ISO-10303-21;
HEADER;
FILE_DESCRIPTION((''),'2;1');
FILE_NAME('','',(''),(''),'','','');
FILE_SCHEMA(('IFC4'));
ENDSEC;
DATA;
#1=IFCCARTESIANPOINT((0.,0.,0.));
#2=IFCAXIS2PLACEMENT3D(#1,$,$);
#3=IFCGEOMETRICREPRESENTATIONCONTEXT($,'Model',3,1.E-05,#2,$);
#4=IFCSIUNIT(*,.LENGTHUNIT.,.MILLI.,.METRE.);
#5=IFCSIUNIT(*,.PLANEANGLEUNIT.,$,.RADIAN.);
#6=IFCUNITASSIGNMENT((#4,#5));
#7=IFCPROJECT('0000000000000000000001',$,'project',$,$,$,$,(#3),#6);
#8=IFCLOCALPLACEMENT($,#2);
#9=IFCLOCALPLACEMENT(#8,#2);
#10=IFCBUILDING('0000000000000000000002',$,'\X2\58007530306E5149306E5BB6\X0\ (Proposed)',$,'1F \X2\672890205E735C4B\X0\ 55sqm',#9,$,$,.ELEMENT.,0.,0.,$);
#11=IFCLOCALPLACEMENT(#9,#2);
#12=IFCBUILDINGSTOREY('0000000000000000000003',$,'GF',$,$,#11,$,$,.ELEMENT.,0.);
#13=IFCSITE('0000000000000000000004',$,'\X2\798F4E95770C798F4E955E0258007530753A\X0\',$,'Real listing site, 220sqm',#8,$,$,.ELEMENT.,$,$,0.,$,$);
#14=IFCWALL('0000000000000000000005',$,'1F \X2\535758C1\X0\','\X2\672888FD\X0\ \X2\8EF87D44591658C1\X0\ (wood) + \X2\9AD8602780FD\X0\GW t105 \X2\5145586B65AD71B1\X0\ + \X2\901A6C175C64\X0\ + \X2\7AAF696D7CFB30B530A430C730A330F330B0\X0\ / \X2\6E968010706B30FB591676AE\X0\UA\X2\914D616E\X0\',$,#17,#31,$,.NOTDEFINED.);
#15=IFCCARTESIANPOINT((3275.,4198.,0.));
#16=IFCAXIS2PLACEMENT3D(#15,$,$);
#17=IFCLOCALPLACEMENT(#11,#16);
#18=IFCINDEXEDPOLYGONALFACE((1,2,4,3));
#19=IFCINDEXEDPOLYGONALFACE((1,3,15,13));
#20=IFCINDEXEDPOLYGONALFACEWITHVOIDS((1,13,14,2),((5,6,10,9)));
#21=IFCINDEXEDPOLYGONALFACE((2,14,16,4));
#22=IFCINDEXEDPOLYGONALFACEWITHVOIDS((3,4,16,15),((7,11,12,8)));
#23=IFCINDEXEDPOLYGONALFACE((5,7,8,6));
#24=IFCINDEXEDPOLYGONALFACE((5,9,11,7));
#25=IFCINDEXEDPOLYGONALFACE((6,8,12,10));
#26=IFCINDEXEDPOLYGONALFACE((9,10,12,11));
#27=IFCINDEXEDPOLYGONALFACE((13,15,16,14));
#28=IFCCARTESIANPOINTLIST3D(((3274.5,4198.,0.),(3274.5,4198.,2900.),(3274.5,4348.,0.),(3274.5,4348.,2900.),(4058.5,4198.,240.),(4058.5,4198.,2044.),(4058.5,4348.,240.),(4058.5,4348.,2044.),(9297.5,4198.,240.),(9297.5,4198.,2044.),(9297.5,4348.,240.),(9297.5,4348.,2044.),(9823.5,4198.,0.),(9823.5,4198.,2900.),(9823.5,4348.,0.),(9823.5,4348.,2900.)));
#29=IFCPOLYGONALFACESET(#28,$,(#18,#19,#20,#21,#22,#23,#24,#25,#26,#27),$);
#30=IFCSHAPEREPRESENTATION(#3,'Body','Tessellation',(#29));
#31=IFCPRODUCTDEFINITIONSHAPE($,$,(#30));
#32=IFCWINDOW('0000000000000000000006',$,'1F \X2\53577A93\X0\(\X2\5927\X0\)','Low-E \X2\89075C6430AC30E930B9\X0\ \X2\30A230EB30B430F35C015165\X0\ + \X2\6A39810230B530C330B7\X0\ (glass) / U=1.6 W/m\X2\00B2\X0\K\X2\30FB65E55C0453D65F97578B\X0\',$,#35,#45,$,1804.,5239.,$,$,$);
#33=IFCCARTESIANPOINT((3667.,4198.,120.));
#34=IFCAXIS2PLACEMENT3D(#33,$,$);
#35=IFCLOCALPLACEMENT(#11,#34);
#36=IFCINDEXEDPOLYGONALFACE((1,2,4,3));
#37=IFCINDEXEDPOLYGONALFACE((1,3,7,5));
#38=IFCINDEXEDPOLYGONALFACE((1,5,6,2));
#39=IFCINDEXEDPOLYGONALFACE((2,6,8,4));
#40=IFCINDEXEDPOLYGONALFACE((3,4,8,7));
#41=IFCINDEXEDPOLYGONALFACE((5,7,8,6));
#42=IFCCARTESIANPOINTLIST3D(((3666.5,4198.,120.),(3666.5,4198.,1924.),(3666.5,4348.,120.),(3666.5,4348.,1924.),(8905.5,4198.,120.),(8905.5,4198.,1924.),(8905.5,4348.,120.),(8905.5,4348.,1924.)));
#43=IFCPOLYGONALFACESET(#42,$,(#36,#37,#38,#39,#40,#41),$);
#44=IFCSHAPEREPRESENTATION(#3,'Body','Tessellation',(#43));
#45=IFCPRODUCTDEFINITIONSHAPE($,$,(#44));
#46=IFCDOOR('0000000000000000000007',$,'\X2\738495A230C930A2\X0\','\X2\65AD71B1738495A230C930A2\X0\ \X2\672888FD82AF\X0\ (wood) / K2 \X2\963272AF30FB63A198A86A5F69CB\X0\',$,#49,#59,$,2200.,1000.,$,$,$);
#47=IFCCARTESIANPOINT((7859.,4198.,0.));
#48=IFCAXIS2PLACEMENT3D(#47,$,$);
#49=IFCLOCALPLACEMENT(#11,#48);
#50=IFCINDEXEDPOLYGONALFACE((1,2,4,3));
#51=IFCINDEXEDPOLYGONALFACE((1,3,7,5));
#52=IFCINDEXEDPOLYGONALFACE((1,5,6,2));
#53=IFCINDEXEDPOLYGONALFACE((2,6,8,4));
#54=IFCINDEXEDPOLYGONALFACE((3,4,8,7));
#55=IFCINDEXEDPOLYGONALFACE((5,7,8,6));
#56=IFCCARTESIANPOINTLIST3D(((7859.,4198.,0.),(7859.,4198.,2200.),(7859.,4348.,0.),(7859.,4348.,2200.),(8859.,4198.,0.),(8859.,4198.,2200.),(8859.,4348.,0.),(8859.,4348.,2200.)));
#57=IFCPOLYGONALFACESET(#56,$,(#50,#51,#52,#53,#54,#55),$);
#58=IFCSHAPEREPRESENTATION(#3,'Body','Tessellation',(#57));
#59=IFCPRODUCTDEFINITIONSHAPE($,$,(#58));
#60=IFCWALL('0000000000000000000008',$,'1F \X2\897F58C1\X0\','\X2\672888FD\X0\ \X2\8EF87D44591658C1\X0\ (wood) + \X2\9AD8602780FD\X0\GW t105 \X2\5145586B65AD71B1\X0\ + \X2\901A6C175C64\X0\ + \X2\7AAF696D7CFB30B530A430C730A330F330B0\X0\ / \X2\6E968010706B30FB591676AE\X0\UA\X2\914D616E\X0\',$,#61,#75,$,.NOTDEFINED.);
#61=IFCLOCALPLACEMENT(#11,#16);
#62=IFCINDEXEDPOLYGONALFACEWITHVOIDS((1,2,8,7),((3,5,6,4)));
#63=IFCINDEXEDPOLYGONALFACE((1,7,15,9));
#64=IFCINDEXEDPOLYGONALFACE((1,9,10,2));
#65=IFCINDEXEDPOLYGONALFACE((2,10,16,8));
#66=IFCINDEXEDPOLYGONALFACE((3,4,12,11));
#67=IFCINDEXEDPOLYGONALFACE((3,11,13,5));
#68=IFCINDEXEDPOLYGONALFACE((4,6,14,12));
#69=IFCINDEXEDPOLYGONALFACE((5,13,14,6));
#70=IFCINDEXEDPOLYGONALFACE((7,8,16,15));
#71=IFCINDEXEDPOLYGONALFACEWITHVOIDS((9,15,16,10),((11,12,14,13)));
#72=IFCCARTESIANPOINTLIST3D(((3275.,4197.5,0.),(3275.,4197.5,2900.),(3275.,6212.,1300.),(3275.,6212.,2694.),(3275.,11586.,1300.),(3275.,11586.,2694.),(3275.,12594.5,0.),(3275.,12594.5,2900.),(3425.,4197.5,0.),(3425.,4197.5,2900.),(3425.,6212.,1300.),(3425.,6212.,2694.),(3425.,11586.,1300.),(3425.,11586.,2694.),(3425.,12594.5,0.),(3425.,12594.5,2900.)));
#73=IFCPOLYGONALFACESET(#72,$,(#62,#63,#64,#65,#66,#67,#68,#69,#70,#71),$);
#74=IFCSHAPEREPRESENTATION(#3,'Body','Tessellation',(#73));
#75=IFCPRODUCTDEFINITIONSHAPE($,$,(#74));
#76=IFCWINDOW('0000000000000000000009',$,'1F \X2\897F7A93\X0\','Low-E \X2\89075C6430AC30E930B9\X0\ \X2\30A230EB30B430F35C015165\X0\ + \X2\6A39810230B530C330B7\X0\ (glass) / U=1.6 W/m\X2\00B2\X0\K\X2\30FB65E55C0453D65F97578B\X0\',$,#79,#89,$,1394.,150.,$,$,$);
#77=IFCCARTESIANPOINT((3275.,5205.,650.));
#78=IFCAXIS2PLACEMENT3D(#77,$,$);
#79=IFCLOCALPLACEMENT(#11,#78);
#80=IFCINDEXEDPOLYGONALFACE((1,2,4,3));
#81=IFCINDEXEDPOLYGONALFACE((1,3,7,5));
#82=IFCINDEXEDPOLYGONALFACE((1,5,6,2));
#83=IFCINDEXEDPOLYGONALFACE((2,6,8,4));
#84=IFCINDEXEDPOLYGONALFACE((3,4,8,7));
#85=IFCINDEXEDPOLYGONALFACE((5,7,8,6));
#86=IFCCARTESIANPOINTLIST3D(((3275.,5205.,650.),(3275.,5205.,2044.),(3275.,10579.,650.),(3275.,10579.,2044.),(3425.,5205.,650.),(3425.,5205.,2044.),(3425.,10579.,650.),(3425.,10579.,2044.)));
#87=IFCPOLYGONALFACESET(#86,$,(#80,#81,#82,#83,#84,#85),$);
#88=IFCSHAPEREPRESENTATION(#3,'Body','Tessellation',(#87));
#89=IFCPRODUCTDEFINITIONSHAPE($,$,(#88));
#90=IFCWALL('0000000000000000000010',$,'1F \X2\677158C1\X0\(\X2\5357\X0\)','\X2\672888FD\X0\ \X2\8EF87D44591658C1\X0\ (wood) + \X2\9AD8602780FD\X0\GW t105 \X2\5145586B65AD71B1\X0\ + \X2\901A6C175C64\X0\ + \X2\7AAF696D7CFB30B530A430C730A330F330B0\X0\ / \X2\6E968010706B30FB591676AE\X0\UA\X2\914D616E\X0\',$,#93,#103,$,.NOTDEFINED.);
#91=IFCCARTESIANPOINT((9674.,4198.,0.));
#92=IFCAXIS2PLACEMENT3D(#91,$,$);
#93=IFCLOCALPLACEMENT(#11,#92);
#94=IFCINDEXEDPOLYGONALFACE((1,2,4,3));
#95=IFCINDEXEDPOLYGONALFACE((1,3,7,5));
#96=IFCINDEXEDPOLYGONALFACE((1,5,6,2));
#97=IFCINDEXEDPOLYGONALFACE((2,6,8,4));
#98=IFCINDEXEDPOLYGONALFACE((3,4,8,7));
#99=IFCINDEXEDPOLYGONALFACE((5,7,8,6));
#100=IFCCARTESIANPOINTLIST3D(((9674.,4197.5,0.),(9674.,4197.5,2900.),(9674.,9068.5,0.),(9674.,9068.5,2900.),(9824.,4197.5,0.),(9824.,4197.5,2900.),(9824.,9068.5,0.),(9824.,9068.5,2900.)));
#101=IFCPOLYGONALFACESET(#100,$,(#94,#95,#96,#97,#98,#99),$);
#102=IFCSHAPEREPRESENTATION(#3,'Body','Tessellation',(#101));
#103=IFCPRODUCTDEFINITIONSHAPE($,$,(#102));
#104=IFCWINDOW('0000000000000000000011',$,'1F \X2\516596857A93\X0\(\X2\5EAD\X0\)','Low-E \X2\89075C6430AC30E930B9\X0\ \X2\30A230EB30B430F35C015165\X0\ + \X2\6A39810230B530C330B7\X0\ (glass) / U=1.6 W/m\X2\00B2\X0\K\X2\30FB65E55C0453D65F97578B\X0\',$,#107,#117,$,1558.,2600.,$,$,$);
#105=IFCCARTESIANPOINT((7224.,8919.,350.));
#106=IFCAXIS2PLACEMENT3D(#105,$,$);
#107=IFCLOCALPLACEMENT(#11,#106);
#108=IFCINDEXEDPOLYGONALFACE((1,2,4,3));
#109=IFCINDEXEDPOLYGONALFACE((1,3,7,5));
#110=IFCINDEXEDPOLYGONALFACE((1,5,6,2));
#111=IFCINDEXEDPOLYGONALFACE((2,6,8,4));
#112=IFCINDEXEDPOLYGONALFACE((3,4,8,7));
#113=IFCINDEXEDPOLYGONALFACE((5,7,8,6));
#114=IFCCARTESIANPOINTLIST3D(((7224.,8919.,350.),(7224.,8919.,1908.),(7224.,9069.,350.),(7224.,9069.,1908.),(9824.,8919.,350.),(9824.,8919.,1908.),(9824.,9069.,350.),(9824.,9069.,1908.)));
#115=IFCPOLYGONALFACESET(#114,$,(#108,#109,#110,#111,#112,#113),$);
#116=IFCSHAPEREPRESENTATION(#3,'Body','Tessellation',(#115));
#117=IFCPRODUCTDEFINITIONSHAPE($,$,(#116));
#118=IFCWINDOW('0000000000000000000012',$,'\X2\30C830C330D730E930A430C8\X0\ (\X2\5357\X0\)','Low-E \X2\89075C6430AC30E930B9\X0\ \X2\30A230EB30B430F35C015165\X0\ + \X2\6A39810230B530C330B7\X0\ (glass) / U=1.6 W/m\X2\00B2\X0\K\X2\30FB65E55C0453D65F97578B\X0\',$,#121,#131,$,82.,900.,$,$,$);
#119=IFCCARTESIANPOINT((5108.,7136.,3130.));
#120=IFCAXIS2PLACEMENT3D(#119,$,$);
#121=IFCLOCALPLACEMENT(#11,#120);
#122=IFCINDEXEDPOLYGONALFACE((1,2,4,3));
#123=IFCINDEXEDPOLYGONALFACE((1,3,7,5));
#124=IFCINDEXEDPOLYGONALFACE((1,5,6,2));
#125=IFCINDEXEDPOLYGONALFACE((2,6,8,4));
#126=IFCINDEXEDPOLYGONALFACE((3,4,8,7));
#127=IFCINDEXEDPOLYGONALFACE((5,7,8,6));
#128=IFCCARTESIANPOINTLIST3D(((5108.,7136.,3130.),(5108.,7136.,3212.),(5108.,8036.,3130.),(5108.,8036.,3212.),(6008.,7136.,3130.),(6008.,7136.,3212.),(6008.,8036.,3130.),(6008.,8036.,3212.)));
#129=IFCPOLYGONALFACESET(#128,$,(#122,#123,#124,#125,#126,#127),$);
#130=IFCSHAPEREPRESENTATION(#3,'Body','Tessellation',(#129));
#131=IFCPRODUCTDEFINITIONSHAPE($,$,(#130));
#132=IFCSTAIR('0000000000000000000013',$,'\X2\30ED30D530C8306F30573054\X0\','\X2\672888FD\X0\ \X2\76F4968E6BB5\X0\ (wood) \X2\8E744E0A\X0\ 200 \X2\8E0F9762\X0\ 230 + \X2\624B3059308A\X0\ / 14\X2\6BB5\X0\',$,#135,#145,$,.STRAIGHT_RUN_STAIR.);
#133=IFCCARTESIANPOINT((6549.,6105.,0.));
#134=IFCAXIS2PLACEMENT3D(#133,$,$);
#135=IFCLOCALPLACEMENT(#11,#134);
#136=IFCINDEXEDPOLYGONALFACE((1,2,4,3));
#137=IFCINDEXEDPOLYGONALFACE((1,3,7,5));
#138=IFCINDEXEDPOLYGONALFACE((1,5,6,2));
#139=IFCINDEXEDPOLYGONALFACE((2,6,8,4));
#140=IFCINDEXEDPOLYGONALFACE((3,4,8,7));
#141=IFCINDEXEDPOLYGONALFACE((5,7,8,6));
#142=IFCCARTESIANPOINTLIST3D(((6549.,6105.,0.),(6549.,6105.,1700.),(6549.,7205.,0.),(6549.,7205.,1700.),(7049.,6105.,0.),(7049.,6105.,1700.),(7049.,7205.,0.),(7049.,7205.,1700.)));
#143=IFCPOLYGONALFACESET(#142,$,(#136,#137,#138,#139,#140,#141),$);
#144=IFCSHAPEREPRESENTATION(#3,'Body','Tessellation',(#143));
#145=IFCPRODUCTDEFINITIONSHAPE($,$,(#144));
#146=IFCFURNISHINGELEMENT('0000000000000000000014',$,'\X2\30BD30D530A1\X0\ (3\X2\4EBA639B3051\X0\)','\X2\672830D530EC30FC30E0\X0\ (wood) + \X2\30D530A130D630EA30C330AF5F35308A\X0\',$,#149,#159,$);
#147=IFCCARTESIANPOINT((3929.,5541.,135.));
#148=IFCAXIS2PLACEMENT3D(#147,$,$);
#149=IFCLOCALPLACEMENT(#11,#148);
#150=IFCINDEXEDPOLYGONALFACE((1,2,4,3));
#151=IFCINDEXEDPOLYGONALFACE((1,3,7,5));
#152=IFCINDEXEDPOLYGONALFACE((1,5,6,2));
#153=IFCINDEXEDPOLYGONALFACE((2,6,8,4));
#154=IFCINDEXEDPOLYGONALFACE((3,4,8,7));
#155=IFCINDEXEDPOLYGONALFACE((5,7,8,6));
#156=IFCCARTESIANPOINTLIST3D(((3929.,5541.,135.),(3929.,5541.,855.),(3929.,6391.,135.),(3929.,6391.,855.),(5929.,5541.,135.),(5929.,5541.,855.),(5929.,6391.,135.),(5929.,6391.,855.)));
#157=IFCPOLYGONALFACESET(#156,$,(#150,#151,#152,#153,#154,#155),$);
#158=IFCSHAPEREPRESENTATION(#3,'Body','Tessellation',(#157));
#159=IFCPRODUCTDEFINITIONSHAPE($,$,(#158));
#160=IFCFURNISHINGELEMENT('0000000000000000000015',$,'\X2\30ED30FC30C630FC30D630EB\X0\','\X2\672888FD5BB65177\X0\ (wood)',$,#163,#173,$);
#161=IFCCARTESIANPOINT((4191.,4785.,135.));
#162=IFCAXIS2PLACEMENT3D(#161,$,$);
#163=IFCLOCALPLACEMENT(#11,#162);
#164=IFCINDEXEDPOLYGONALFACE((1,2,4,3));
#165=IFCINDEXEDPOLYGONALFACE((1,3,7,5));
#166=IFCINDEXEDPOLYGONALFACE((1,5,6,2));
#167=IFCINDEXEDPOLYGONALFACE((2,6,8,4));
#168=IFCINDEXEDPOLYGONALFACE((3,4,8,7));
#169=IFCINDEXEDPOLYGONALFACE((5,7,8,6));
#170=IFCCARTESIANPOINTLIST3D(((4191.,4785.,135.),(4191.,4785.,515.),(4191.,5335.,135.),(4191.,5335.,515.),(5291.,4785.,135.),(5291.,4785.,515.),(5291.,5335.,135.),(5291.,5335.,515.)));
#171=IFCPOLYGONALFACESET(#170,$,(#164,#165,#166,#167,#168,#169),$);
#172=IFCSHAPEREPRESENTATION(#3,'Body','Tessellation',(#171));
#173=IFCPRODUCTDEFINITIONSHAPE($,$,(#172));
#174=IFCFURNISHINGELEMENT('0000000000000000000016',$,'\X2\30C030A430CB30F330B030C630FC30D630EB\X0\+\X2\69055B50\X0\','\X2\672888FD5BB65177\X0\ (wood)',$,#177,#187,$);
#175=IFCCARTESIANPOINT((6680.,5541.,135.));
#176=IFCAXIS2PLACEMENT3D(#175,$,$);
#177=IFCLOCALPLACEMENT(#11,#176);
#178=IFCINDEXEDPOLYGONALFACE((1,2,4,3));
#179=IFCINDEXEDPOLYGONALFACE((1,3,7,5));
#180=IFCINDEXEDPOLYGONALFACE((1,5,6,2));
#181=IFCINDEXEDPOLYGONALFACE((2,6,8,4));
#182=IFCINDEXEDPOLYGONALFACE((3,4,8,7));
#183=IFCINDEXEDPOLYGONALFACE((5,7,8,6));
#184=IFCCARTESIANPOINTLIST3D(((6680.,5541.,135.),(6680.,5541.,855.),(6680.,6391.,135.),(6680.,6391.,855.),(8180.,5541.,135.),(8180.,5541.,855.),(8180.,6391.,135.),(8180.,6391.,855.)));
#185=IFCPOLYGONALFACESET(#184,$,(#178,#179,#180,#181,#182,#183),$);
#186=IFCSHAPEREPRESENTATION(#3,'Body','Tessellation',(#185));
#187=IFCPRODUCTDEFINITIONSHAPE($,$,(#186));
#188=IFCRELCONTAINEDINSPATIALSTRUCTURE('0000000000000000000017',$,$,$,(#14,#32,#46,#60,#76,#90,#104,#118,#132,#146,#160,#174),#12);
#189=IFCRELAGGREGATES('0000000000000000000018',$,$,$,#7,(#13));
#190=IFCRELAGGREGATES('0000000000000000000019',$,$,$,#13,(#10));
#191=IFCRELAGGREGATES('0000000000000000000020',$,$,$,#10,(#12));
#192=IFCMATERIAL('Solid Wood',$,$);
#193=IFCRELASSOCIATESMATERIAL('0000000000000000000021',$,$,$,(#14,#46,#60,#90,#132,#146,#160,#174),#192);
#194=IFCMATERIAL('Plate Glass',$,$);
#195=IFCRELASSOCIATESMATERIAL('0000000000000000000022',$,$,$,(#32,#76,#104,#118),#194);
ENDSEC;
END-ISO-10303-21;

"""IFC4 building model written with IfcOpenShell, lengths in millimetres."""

from ifc_helpers import new_model, si_unit, frame, frame_2d, origin, place, context, project, spatial, rectangle, extrude, material, element, fill, save


model = new_model("IFC4")

# Units and contexts
model_context = context("Model", 3, precision=1e-05, world=origin())
ifc_project = project(units=[si_unit("LENGTHUNIT", "METRE", prefix="MILLI"), si_unit("PLANEANGLEUNIT", "RADIAN")], contexts=[model_context])

# Site, building, storey
site_placement = place(None, origin())
site = spatial("IfcSite", under=ifc_project, at=site_placement, Name="福井県福井市堀田町", ObjectType="Real listing site, 220sqm", CompositionType="ELEMENT", RefElevation=0.0)
building_placement = place(site_placement, origin())
building = spatial("IfcBuilding", under=site, at=building_placement, Name="堀田の光の家 (Proposed)", ObjectType="1F 木造平屋 55sqm", CompositionType="ELEMENT", ElevationOfRefHeight=0.0, ElevationOfTerrain=0.0)
storey_placement = place(building_placement, origin())
storey = spatial("IfcBuildingStorey", under=building, at=storey_placement, Name="GF", CompositionType="ELEMENT", Elevation=0.0)

# Shared definitions
ifc_material_1 = material(Name="Solid Wood")

# Wall, openings, window, door
wall_1_placement = place(storey_placement, frame((3275.0, 4198.0, 0.0)))
wall_1 = element("IfcWall", 1, at=wall_1_placement, inside=storey, material=ifc_material_1, Name="1F 南壁", Description="木製 軸組外壁 (wood) + 高性能GW t105 充填断熱 + 通気層 + 窯業系サイディング / 準耐火・外皮UA配慮", PredefinedType="NOTDEFINED", context=model_context, shape_type="SweptSolid", body=[
    extrude(rectangle(XDim=6549.0, YDim=150.0, at=frame_2d((3274.0, 75.0))), frame((3275.0, 4198.0, 0.0)), (0.0, 0.0, 1.0), 2900.0),
])
opening_1_placement = place(storey_placement, frame((3667.0, 4198.0, 120.0)))
opening_1 = element("IfcOpeningElement", 2, at=opening_1_placement, cuts=wall_1, PredefinedType="NOTDEFINED", context=model_context, shape_type="SweptSolid", body=[
    extrude(rectangle(XDim=5239.0, YDim=150.0, at=frame_2d((2619.0, 75.0))), frame((3667.0, 4198.0, 120.0)), (0.0, 0.0, 1.0), 1804.0),
])
opening_2_placement = place(storey_placement, frame((7859.0, 4198.0, 0.0)))
opening_2 = element("IfcOpeningElement", 3, at=opening_2_placement, cuts=wall_1, PredefinedType="NOTDEFINED", context=model_context, shape_type="SweptSolid", body=[
    extrude(rectangle(XDim=1000.0, YDim=150.0, at=frame_2d((500.0, 75.0))), frame((7859.0, 4198.0, 0.0)), (0.0, 0.0, 1.0), 2200.0),
])
ifc_material_2 = material(Name="Plate Glass")
window_1_placement = place(storey_placement, frame((3667.0, 4198.0, 120.0)))
window_1 = element("IfcWindow", 4, at=window_1_placement, inside=storey, material=ifc_material_2, Name="1F 南窓(大)", Description="Low-E 複層ガラス アルゴン封入 + 樹脂サッシ (glass) / U=1.6 W/m²K・日射取得型", OverallHeight=1804.0, OverallWidth=5239.0, context=model_context, shape_type="SweptSolid", body=[
    extrude(rectangle(XDim=5239.0, YDim=150.0, at=frame_2d((2619.0, 75.0))), frame((3667.0, 4198.0, 120.0)), (0.0, 0.0, 1.0), 1804.0),
])
fill(opening_1, window_1)
door_1_placement = place(storey_placement, frame((7859.0, 4198.0, 0.0)))
door_1 = element("IfcDoor", 5, at=door_1_placement, inside=storey, material=ifc_material_1, Name="玄関ドア", Description="断熱玄関ドア 木製芯 (wood) / K2 防犯・採風機構", OverallHeight=2200.0, OverallWidth=1000.0, context=model_context, shape_type="SweptSolid", body=[
    extrude(rectangle(XDim=1000.0, YDim=150.0, at=frame_2d((500.0, 75.0))), frame((7859.0, 4198.0, 0.0)), (0.0, 0.0, 1.0), 2200.0),
])
fill(opening_2, door_1)

# Walls, openings, windows
wall_2_placement = place(storey_placement, frame((3275.0, 4198.0, 0.0)))
wall_2 = element("IfcWall", 6, at=wall_2_placement, inside=storey, material=ifc_material_1, Name="1F 西壁", Description="木製 軸組外壁 (wood) + 高性能GW t105 充填断熱 + 通気層 + 窯業系サイディング / 準耐火・外皮UA配慮", PredefinedType="NOTDEFINED", context=model_context, shape_type="SweptSolid", body=[
    extrude(rectangle(XDim=150.0, YDim=8397.0, at=frame_2d((75.0, 4198.0))), frame((3275.0, 4198.0, 0.0)), (0.0, 0.0, 1.0), 2900.0),
])
opening_3_placement = place(storey_placement, frame((3275.0, 5205.0, 650.0)))
opening_3 = element("IfcOpeningElement", 7, at=opening_3_placement, cuts=wall_2, PredefinedType="NOTDEFINED", context=model_context, shape_type="SweptSolid", body=[
    extrude(rectangle(XDim=150.0, YDim=5374.0, at=frame_2d((75.0, 2687.0))), frame((3275.0, 5205.0, 650.0)), (0.0, 0.0, 1.0), 1394.0),
])
window_2_placement = place(storey_placement, frame((3275.0, 5205.0, 650.0)))
window_2 = element("IfcWindow", 8, at=window_2_placement, inside=storey, material=ifc_material_2, Name="1F 西窓", Description="Low-E 複層ガラス アルゴン封入 + 樹脂サッシ (glass) / U=1.6 W/m²K・日射取得型", OverallHeight=1394.0, OverallWidth=150.0, context=model_context, shape_type="SweptSolid", body=[
    extrude(rectangle(XDim=150.0, YDim=5374.0, at=frame_2d((75.0, 2687.0))), frame((3275.0, 5205.0, 650.0)), (0.0, 0.0, 1.0), 1394.0),
])
fill(opening_3, window_2)
wall_3_placement = place(storey_placement, frame((9674.0, 4198.0, 0.0)))
wall_3 = element("IfcWall", 9, at=wall_3_placement, inside=storey, material=ifc_material_1, Name="1F 東壁(南)", Description="木製 軸組外壁 (wood) + 高性能GW t105 充填断熱 + 通気層 + 窯業系サイディング / 準耐火・外皮UA配慮", PredefinedType="NOTDEFINED", context=model_context, shape_type="SweptSolid", body=[
    extrude(rectangle(XDim=150.0, YDim=4871.0, at=frame_2d((75.0, 2435.0))), frame((9674.0, 4198.0, 0.0)), (0.0, 0.0, 1.0), 2900.0),
])
opening_4_placement = place(storey_placement, frame((7224.0, 8919.0, 350.0)))
opening_4 = element("IfcOpeningElement", 10, at=opening_4_placement, cuts=wall_3, PredefinedType="NOTDEFINED", context=model_context, shape_type="SweptSolid", body=[
    extrude(rectangle(XDim=2600.0, YDim=150.0, at=frame_2d((1300.0, 75.0))), frame((7224.0, 8919.0, 350.0)), (0.0, 0.0, 1.0), 1558.0),
])
window_3_placement = place(storey_placement, frame((7224.0, 8919.0, 350.0)))
window_3 = element("IfcWindow", 11, at=window_3_placement, inside=storey, material=ifc_material_2, Name="1F 入隅窓(庭)", Description="Low-E 複層ガラス アルゴン封入 + 樹脂サッシ (glass) / U=1.6 W/m²K・日射取得型", OverallHeight=1558.0, OverallWidth=2600.0, context=model_context, shape_type="SweptSolid", body=[
    extrude(rectangle(XDim=2600.0, YDim=150.0, at=frame_2d((1300.0, 75.0))), frame((7224.0, 8919.0, 350.0)), (0.0, 0.0, 1.0), 1558.0),
])
fill(opening_4, window_3)

# Window
window_4_placement = place(storey_placement, frame((5108.0, 7136.0, 3130.0)))
element("IfcWindow", 12, at=window_4_placement, inside=storey, material=ifc_material_2, Name="トップライト (南)", Description="Low-E 複層ガラス アルゴン封入 + 樹脂サッシ (glass) / U=1.6 W/m²K・日射取得型", OverallHeight=82.0, OverallWidth=900.0, context=model_context, shape_type="SweptSolid", body=[
    extrude(rectangle(XDim=900.0, YDim=900.0, at=frame_2d((450.0, 450.0))), frame((5108.0, 7136.0, 3130.0)), (0.0, 0.0, 1.0), 82.0),
])

# Stair
stair_placement = place(storey_placement, frame((6549.0, 6105.0, 0.0)))
element("IfcStair", 13, at=stair_placement, inside=storey, material=ifc_material_1, Name="ロフトはしご", Description="木製 直階段 (wood) 蹴上 200 踏面 230 + 手すり / 14段", PredefinedType="STRAIGHT_RUN_STAIR", context=model_context, shape_type="SweptSolid", body=[
    extrude(rectangle(XDim=500.0, YDim=1100.0, at=frame_2d((250.0, 550.0))), frame((6549.0, 6105.0, 0.0)), (0.0, 0.0, 1.0), 1700.0),
])

# Furnishing elements
furnishing_1_placement = place(storey_placement, frame((3929.0, 5541.0, 135.0)))
element("IfcFurnishingElement", 14, at=furnishing_1_placement, inside=storey, material=ifc_material_1, Name="ソファ (3人掛け)", Description="木フレーム (wood) + ファブリック張り", context=model_context, shape_type="SweptSolid", body=[
    extrude(rectangle(XDim=2000.0, YDim=850.0, at=frame_2d((1000.0, 425.0))), frame((3929.0, 5541.0, 135.0)), (0.0, 0.0, 1.0), 720.0),
])
furnishing_2_placement = place(storey_placement, frame((4191.0, 4785.0, 135.0)))
element("IfcFurnishingElement", 15, at=furnishing_2_placement, inside=storey, material=ifc_material_1, Name="ローテーブル", Description="木製家具 (wood)", context=model_context, shape_type="SweptSolid", body=[
    extrude(rectangle(XDim=1100.0, YDim=550.0, at=frame_2d((550.0, 275.0))), frame((4191.0, 4785.0, 135.0)), (0.0, 0.0, 1.0), 380.0),
])
furnishing_3_placement = place(storey_placement, frame((6680.0, 5541.0, 135.0)))
element("IfcFurnishingElement", 16, at=furnishing_3_placement, inside=storey, material=ifc_material_1, Name="ダイニングテーブル+椅子", Description="木製家具 (wood)", context=model_context, shape_type="SweptSolid", body=[
    extrude(rectangle(XDim=1500.0, YDim=850.0, at=frame_2d((750.0, 425.0))), frame((6680.0, 5541.0, 135.0)), (0.0, 0.0, 1.0), 720.0),
])

save(model, "model.ifc")
